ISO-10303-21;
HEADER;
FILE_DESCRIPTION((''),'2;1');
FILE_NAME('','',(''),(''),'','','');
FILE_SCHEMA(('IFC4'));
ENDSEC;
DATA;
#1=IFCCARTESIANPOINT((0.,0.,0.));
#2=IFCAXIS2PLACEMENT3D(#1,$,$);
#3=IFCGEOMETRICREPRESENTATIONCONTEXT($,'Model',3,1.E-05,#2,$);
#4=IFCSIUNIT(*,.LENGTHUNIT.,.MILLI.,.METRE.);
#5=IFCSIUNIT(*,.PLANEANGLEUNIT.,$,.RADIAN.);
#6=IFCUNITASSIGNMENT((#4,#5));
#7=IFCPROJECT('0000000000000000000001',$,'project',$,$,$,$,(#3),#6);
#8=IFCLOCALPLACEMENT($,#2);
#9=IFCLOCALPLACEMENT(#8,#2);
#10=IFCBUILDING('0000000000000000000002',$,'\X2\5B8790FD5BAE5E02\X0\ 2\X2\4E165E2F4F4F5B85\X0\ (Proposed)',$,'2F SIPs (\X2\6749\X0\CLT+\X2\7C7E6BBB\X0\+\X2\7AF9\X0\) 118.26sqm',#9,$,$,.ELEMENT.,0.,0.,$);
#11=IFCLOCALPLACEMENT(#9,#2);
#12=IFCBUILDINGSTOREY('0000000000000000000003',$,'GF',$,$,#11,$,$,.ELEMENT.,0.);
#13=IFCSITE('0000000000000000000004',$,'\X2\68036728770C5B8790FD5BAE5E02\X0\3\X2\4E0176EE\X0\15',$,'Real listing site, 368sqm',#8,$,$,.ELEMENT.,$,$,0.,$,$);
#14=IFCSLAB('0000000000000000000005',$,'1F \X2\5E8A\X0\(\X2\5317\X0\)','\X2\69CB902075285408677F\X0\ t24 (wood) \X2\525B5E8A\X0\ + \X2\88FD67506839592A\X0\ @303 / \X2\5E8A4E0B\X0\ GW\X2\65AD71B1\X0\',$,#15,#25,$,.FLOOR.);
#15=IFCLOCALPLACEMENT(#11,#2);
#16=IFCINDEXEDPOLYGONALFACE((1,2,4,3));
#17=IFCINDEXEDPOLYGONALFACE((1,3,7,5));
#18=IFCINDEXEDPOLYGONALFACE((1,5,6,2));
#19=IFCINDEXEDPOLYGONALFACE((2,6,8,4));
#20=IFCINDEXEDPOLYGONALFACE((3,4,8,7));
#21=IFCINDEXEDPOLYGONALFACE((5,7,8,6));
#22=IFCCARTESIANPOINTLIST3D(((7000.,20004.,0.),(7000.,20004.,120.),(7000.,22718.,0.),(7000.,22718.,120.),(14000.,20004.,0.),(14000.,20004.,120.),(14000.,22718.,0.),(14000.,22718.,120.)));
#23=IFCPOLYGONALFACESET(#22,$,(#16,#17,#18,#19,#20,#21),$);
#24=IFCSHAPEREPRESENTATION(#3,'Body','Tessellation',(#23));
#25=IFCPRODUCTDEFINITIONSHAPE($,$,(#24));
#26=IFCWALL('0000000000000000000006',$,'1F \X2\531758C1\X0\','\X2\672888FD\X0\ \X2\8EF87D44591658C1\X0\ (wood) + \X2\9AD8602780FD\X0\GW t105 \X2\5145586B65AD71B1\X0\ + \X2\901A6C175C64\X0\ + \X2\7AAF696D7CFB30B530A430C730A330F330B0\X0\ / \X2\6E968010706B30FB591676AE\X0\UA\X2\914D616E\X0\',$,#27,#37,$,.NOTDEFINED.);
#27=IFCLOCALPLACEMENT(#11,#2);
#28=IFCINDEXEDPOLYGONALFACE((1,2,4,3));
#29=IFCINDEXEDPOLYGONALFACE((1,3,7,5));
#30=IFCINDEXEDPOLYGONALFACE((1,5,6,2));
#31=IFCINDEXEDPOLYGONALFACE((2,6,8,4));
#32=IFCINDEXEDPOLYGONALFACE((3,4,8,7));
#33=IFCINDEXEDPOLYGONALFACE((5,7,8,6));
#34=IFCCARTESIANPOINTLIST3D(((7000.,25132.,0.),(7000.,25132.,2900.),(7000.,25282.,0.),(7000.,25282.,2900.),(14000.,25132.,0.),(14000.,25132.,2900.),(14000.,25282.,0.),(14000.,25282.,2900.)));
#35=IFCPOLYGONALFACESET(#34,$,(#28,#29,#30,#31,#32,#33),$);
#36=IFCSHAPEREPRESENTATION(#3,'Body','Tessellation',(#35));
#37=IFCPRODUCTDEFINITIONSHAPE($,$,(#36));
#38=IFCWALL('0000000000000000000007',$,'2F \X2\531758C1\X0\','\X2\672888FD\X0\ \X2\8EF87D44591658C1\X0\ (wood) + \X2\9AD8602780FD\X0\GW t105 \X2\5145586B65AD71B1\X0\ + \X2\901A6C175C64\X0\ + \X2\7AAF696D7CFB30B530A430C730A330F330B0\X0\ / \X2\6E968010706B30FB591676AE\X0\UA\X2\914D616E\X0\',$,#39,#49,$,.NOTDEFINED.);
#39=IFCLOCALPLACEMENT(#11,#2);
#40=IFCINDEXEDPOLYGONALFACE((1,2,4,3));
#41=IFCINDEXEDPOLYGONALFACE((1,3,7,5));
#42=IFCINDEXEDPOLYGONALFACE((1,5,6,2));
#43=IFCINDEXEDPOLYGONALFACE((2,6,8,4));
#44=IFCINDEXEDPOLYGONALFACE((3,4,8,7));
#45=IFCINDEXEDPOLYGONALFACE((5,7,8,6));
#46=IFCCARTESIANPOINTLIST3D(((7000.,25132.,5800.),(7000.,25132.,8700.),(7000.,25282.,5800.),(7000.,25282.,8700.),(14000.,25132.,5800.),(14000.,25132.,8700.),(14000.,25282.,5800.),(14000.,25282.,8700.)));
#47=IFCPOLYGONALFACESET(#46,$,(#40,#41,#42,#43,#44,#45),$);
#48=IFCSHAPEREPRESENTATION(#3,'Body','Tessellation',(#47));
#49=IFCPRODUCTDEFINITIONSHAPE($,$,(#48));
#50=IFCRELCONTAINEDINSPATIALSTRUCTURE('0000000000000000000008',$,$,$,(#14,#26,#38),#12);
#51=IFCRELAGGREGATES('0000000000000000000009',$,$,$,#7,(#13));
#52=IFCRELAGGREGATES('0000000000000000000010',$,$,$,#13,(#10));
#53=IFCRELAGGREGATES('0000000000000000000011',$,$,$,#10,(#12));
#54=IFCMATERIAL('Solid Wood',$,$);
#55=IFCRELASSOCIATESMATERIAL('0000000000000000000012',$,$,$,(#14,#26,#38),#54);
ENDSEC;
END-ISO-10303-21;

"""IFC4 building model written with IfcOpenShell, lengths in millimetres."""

from ifc_helpers import new_model, si_unit, frame, frame_2d, origin, place, context, project, spatial, rectangle, extrude, material, element, save


model = new_model("IFC4")

# Units and contexts
model_context = context("Model", 3, precision=1e-05, world=origin())
ifc_project = project(units=[si_unit("LENGTHUNIT", "METRE", prefix="MILLI"), si_unit("PLANEANGLEUNIT", "RADIAN")], contexts=[model_context])

# Site, building, storey
site_placement = place(None, origin())
site = spatial("IfcSite", under=ifc_project, at=site_placement, Name="栃木県宇都宮市3丁目15", ObjectType="Real listing site, 368sqm", CompositionType="ELEMENT", RefElevation=0.0)
building_placement = place(site_placement, origin())
building = spatial("IfcBuilding", under=site, at=building_placement, Name="宇都宮市 2世帯住宅 (Proposed)", ObjectType="2F SIPs (杉CLT+籾殻+竹) 118.26sqm", CompositionType="ELEMENT", ElevationOfRefHeight=0.0, ElevationOfTerrain=0.0)
storey_placement = place(building_placement, origin())
storey = spatial("IfcBuildingStorey", under=building, at=storey_placement, Name="GF", CompositionType="ELEMENT", Elevation=0.0)

# Slab
ifc_material_1 = material(Name="Solid Wood")
slab_1_placement = place(storey_placement, frame((3500.0, 10002.0, 0.0)))
element("IfcSlab", 1, at=slab_1_placement, inside=storey, material=ifc_material_1, Name="1F 床(北)", Description="構造用合板 t24 (wood) 剛床 + 製材根太 @303 / 床下 GW断熱", PredefinedType="FLOOR", context=model_context, shape_type="SweptSolid", body=[
    extrude(rectangle(XDim=7000.0, YDim=2714.0, at=frame_2d((3500.0, 1357.0))), frame((3500.0, 10002.0, 0.0)), (0.0, 0.0, 1.0), 120.0),
])

# Wall
wall_1_placement = place(storey_placement, frame((3500.0, 12566.0, 0.0)))
element("IfcWall", 2, at=wall_1_placement, inside=storey, material=ifc_material_1, Name="1F 北壁", Description="木製 軸組外壁 (wood) + 高性能GW t105 充填断熱 + 通気層 + 窯業系サイディング / 準耐火・外皮UA配慮", PredefinedType="NOTDEFINED", context=model_context, shape_type="SweptSolid", body=[
    extrude(rectangle(XDim=7000.0, YDim=150.0, at=frame_2d((3500.0, 75.0))), frame((3500.0, 12566.0, 0.0)), (0.0, 0.0, 1.0), 2900.0),
])

# Wall
wall_2_placement = place(storey_placement, frame((3500.0, 12566.0, 2900.0)))
element("IfcWall", 3, at=wall_2_placement, inside=storey, material=ifc_material_1, Name="2F 北壁", Description="木製 軸組外壁 (wood) + 高性能GW t105 充填断熱 + 通気層 + 窯業系サイディング / 準耐火・外皮UA配慮", PredefinedType="NOTDEFINED", context=model_context, shape_type="SweptSolid", body=[
    extrude(rectangle(XDim=7000.0, YDim=150.0, at=frame_2d((3500.0, 75.0))), frame((3500.0, 12566.0, 2900.0)), (0.0, 0.0, 1.0), 2900.0),
])

save(model, "model.ifc")
